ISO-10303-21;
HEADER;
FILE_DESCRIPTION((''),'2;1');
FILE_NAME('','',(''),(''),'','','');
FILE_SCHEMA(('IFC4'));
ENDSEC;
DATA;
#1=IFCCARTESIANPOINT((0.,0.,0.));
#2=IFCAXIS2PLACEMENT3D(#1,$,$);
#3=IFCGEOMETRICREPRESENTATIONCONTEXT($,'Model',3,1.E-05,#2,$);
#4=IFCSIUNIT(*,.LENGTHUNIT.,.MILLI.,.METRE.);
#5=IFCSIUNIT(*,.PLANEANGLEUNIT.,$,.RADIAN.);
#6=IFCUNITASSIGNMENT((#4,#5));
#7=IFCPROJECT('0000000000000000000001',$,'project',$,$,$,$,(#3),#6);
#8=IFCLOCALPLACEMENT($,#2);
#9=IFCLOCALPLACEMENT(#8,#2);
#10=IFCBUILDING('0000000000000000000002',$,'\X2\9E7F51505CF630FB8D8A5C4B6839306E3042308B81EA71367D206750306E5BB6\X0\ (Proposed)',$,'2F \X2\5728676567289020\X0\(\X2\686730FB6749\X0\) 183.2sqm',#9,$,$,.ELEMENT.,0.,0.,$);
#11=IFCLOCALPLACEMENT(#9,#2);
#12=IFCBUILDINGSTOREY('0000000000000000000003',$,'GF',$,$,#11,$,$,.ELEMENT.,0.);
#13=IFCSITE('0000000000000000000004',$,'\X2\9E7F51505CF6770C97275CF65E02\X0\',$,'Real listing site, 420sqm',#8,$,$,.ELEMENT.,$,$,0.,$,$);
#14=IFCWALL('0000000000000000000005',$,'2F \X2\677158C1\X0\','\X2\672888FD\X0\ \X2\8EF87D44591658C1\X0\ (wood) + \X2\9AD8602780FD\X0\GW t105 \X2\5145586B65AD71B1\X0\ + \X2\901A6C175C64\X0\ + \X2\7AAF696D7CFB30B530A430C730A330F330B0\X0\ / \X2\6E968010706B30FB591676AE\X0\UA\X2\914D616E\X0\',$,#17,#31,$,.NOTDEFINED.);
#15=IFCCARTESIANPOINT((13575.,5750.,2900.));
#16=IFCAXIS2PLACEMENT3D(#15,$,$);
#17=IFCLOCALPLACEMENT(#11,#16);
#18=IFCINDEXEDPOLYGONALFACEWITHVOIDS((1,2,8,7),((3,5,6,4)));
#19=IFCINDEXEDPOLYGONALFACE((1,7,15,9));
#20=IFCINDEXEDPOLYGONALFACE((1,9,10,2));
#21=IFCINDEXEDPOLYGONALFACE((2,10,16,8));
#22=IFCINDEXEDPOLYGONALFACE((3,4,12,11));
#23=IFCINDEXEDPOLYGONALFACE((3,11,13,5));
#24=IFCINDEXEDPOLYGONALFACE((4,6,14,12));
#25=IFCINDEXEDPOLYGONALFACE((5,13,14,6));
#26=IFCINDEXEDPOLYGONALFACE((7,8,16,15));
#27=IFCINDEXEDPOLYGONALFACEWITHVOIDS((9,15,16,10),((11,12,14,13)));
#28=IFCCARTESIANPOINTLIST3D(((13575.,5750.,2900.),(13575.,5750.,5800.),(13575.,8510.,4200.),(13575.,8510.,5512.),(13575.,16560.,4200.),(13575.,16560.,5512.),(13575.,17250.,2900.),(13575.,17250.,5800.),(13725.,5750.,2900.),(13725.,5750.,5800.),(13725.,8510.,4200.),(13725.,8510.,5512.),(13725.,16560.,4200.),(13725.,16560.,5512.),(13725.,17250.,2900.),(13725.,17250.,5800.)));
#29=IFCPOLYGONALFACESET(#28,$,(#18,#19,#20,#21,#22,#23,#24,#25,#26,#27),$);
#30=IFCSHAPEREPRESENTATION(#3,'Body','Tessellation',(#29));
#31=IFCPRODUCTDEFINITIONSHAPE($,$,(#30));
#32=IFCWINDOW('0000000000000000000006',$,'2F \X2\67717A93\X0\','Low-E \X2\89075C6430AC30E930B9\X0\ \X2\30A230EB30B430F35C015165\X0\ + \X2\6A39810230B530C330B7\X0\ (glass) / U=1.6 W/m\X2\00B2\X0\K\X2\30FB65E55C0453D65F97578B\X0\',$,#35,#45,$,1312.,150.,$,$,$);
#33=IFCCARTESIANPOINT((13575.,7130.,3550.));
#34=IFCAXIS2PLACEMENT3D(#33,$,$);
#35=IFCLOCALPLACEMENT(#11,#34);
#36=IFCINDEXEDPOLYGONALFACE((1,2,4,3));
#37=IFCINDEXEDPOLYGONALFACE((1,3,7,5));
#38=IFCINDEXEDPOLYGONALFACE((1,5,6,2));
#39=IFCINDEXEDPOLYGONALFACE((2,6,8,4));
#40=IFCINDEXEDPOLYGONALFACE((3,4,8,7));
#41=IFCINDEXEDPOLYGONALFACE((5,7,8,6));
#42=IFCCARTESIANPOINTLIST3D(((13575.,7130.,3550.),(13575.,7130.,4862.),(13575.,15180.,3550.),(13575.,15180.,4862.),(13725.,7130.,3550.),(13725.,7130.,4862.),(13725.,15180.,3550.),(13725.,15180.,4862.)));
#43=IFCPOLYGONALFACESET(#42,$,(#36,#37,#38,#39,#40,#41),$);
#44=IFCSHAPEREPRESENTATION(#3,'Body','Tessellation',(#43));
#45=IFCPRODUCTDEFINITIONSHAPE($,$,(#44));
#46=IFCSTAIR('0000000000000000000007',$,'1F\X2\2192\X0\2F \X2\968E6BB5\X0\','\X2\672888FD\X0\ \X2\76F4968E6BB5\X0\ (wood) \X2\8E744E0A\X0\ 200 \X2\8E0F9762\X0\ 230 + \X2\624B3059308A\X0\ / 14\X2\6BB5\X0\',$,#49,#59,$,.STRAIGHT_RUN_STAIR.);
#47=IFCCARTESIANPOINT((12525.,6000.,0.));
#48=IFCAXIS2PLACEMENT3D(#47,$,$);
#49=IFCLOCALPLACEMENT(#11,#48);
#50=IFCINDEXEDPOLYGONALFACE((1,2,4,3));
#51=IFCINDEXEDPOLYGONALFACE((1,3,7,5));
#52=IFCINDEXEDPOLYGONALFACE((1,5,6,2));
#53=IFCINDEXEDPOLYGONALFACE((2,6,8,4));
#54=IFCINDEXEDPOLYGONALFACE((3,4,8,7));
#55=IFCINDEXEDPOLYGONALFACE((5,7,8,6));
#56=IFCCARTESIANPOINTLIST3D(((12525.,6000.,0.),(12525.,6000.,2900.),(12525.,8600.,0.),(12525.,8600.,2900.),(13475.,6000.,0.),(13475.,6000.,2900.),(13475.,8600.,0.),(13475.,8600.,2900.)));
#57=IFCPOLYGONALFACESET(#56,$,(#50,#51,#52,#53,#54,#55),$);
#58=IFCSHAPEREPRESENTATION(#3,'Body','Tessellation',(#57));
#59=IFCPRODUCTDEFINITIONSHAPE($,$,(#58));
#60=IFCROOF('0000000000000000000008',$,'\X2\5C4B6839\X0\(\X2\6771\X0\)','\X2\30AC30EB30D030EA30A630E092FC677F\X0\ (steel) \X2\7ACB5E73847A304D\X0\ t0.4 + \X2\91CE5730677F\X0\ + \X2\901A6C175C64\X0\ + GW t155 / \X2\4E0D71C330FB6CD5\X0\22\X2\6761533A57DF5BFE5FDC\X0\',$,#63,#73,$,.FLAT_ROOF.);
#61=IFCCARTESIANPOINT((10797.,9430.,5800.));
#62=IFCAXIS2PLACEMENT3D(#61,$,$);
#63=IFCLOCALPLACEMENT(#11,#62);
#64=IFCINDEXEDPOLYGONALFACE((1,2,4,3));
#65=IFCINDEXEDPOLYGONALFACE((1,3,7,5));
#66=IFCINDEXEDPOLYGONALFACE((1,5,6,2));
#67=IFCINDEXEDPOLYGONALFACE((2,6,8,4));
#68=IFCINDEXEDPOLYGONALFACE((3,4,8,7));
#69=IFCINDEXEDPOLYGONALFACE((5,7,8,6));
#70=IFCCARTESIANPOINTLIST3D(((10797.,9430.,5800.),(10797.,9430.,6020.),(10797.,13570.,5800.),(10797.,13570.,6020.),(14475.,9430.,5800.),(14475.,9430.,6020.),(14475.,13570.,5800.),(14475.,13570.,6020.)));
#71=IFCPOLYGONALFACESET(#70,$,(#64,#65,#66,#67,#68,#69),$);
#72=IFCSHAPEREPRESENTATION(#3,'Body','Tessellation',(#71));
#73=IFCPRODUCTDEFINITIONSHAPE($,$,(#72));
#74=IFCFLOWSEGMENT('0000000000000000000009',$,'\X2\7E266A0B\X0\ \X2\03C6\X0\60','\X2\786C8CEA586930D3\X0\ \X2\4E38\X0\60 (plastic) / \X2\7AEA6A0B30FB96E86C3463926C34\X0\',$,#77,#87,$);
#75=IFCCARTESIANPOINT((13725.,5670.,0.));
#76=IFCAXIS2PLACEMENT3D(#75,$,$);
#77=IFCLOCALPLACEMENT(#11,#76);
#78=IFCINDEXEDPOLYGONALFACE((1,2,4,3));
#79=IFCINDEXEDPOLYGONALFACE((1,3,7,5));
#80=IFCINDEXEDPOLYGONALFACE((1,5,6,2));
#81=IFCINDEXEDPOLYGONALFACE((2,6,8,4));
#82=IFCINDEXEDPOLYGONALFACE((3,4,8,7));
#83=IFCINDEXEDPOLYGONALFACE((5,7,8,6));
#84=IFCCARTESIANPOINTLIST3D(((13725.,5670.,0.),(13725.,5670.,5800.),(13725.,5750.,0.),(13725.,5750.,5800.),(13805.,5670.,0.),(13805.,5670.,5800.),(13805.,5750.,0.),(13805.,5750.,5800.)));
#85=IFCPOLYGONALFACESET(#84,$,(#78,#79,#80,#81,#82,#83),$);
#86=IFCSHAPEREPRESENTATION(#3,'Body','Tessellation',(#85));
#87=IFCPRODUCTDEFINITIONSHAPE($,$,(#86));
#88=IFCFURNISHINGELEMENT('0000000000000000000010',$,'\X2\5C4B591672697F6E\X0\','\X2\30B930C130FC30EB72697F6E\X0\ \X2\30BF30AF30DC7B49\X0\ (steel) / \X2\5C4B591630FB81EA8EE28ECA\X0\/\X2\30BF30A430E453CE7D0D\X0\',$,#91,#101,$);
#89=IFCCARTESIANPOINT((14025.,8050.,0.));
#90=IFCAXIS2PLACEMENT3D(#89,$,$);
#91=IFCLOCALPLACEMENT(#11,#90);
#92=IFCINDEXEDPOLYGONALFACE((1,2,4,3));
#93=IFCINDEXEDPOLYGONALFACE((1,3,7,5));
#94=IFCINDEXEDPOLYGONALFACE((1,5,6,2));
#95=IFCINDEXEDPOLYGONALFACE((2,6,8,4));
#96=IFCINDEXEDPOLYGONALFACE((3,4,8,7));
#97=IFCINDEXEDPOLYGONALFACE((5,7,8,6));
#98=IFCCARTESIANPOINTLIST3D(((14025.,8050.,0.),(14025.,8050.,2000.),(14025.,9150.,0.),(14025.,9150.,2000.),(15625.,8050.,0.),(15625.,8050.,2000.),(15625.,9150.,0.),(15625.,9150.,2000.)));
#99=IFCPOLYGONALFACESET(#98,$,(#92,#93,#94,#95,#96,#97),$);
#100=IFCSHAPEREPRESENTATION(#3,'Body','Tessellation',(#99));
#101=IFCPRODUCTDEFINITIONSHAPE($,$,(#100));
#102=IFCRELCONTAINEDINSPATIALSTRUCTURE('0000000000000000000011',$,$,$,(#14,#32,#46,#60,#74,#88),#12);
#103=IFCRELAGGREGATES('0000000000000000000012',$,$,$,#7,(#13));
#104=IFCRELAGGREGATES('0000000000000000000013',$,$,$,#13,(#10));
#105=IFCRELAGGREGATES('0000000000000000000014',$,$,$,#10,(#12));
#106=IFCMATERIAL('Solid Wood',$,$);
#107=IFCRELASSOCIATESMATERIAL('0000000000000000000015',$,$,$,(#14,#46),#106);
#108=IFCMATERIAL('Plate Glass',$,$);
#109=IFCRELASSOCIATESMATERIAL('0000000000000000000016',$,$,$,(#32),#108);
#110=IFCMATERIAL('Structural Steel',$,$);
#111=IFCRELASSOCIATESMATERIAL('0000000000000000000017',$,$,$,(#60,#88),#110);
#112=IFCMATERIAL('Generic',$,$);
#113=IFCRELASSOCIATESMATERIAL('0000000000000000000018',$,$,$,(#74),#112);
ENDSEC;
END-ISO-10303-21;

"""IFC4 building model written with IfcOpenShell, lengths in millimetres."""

from ifc_helpers import new_model, si_unit, frame, frame_2d, origin, place, context, project, spatial, rectangle, extrude, material, element, fill, save


model = new_model("IFC4")

# Units and contexts
model_context = context("Model", 3, precision=1e-05, world=origin())
ifc_project = project(units=[si_unit("LENGTHUNIT", "METRE", prefix="MILLI"), si_unit("PLANEANGLEUNIT", "RADIAN")], contexts=[model_context])

# Site, building, storey
site_placement = place(None, origin())
site = spatial("IfcSite", under=ifc_project, at=site_placement, Name="鹿児島県霧島市", ObjectType="Real listing site, 420sqm", CompositionType="ELEMENT", RefElevation=0.0)
building_placement = place(site_placement, origin())
building = spatial("IfcBuilding", under=site, at=building_placement, Name="鹿児島・越屋根のある自然素材の家 (Proposed)", ObjectType="2F 在来木造(桧・杉) 183.2sqm", CompositionType="ELEMENT", ElevationOfRefHeight=0.0, ElevationOfTerrain=0.0)
storey_placement = place(building_placement, origin())
storey = spatial("IfcBuildingStorey", under=building, at=storey_placement, Name="GF", CompositionType="ELEMENT", Elevation=0.0)

# Shared definitions
ifc_material_1 = material(Name="Solid Wood")

# Wall, opening, window
ifc_material_2 = material(Name="Plate Glass")
wall_1_placement = place(storey_placement, frame((13575.0, 5750.0, 2900.0)))
wall_1 = element("IfcWall", 1, at=wall_1_placement, inside=storey, material=ifc_material_1, Name="2F 東壁", Description="木製 軸組外壁 (wood) + 高性能GW t105 充填断熱 + 通気層 + 窯業系サイディング / 準耐火・外皮UA配慮", PredefinedType="NOTDEFINED", context=model_context, shape_type="SweptSolid", body=[
    extrude(rectangle(XDim=150.0, YDim=11500.0, at=frame_2d((75.0, 5750.0))), frame((13575.0, 5750.0, 2900.0)), (0.0, 0.0, 1.0), 2900.0),
])
opening_1_placement = place(storey_placement, frame((13575.0, 7130.0, 3550.0)))
opening_1 = element("IfcOpeningElement", 2, at=opening_1_placement, cuts=wall_1, PredefinedType="NOTDEFINED", context=model_context, shape_type="SweptSolid", body=[
    extrude(rectangle(XDim=150.0, YDim=8050.0, at=frame_2d((75.0, 4025.0))), frame((13575.0, 7130.0, 3550.0)), (0.0, 0.0, 1.0), 1312.0),
])
window_1_placement = place(storey_placement, frame((13575.0, 7130.0, 3550.0)))
window_1 = element("IfcWindow", 3, at=window_1_placement, inside=storey, material=ifc_material_2, Name="2F 東窓", Description="Low-E 複層ガラス アルゴン封入 + 樹脂サッシ (glass) / U=1.6 W/m²K・日射取得型", OverallHeight=1312.0, OverallWidth=150.0, context=model_context, shape_type="SweptSolid", body=[
    extrude(rectangle(XDim=150.0, YDim=8050.0, at=frame_2d((75.0, 4025.0))), frame((13575.0, 7130.0, 3550.0)), (0.0, 0.0, 1.0), 1312.0),
])
fill(opening_1, window_1)

# Stair
stair_placement = place(storey_placement, frame((12525.0, 6000.0, 0.0)))
element("IfcStair", 4, at=stair_placement, inside=storey, material=ifc_material_1, Name="1F→2F 階段", Description="木製 直階段 (wood) 蹴上 200 踏面 230 + 手すり / 14段", PredefinedType="STRAIGHT_RUN_STAIR", context=model_context, shape_type="SweptSolid", body=[
    extrude(rectangle(XDim=950.0, YDim=2600.0, at=frame_2d((475.0, 1300.0))), frame((12525.0, 6000.0, 0.0)), (0.0, 0.0, 1.0), 2900.0),
])

# Roof
ifc_material_3 = material(Name="Structural Steel")
roof_placement = place(storey_placement, frame((10797.0, 9430.0, 5800.0)))
element("IfcRoof", 5, at=roof_placement, inside=storey, material=ifc_material_3, Name="屋根(東)", Description="ガルバリウム鋼板 (steel) 立平葺き t0.4 + 野地板 + 通気層 + GW t155 / 不燃・法22条区域対応", PredefinedType="FLAT_ROOF", context=model_context, shape_type="SweptSolid", body=[
    extrude(rectangle(XDim=3678.0, YDim=4140.0, at=frame_2d((1839.0, 2070.0))), frame((10797.0, 9430.0, 5800.0)), (0.0, 0.0, 1.0), 220.0),
])

# Flow segment
ifc_material_4 = material(Name="Generic")
flow_segment_placement = place(storey_placement, frame((13725.0, 5670.0, 0.0)))
element("IfcFlowSegment", 6, at=flow_segment_placement, inside=storey, material=ifc_material_4, Name="縦樋 φ60", Description="硬質塩ビ 丸60 (plastic) / 竪樋・雨水排水", context=model_context, shape_type="SweptSolid", body=[
    extrude(rectangle(XDim=80.0, YDim=80.0, at=frame_2d((40.0, 40.0))), frame((13725.0, 5670.0, 0.0)), (0.0, 0.0, 1.0), 5800.0),
])

# Furnishing element
furnishing_placement = place(storey_placement, frame((14025.0, 8050.0, 0.0)))
element("IfcFurnishingElement", 7, at=furnishing_placement, inside=storey, material=ifc_material_3, Name="屋外物置", Description="スチール物置 タクボ等 (steel) / 屋外・自転車/タイヤ収納", context=model_context, shape_type="SweptSolid", body=[
    extrude(rectangle(XDim=1600.0, YDim=1100.0, at=frame_2d((800.0, 550.0))), frame((14025.0, 8050.0, 0.0)), (0.0, 0.0, 1.0), 2000.0),
])

save(model, "model.ifc")
